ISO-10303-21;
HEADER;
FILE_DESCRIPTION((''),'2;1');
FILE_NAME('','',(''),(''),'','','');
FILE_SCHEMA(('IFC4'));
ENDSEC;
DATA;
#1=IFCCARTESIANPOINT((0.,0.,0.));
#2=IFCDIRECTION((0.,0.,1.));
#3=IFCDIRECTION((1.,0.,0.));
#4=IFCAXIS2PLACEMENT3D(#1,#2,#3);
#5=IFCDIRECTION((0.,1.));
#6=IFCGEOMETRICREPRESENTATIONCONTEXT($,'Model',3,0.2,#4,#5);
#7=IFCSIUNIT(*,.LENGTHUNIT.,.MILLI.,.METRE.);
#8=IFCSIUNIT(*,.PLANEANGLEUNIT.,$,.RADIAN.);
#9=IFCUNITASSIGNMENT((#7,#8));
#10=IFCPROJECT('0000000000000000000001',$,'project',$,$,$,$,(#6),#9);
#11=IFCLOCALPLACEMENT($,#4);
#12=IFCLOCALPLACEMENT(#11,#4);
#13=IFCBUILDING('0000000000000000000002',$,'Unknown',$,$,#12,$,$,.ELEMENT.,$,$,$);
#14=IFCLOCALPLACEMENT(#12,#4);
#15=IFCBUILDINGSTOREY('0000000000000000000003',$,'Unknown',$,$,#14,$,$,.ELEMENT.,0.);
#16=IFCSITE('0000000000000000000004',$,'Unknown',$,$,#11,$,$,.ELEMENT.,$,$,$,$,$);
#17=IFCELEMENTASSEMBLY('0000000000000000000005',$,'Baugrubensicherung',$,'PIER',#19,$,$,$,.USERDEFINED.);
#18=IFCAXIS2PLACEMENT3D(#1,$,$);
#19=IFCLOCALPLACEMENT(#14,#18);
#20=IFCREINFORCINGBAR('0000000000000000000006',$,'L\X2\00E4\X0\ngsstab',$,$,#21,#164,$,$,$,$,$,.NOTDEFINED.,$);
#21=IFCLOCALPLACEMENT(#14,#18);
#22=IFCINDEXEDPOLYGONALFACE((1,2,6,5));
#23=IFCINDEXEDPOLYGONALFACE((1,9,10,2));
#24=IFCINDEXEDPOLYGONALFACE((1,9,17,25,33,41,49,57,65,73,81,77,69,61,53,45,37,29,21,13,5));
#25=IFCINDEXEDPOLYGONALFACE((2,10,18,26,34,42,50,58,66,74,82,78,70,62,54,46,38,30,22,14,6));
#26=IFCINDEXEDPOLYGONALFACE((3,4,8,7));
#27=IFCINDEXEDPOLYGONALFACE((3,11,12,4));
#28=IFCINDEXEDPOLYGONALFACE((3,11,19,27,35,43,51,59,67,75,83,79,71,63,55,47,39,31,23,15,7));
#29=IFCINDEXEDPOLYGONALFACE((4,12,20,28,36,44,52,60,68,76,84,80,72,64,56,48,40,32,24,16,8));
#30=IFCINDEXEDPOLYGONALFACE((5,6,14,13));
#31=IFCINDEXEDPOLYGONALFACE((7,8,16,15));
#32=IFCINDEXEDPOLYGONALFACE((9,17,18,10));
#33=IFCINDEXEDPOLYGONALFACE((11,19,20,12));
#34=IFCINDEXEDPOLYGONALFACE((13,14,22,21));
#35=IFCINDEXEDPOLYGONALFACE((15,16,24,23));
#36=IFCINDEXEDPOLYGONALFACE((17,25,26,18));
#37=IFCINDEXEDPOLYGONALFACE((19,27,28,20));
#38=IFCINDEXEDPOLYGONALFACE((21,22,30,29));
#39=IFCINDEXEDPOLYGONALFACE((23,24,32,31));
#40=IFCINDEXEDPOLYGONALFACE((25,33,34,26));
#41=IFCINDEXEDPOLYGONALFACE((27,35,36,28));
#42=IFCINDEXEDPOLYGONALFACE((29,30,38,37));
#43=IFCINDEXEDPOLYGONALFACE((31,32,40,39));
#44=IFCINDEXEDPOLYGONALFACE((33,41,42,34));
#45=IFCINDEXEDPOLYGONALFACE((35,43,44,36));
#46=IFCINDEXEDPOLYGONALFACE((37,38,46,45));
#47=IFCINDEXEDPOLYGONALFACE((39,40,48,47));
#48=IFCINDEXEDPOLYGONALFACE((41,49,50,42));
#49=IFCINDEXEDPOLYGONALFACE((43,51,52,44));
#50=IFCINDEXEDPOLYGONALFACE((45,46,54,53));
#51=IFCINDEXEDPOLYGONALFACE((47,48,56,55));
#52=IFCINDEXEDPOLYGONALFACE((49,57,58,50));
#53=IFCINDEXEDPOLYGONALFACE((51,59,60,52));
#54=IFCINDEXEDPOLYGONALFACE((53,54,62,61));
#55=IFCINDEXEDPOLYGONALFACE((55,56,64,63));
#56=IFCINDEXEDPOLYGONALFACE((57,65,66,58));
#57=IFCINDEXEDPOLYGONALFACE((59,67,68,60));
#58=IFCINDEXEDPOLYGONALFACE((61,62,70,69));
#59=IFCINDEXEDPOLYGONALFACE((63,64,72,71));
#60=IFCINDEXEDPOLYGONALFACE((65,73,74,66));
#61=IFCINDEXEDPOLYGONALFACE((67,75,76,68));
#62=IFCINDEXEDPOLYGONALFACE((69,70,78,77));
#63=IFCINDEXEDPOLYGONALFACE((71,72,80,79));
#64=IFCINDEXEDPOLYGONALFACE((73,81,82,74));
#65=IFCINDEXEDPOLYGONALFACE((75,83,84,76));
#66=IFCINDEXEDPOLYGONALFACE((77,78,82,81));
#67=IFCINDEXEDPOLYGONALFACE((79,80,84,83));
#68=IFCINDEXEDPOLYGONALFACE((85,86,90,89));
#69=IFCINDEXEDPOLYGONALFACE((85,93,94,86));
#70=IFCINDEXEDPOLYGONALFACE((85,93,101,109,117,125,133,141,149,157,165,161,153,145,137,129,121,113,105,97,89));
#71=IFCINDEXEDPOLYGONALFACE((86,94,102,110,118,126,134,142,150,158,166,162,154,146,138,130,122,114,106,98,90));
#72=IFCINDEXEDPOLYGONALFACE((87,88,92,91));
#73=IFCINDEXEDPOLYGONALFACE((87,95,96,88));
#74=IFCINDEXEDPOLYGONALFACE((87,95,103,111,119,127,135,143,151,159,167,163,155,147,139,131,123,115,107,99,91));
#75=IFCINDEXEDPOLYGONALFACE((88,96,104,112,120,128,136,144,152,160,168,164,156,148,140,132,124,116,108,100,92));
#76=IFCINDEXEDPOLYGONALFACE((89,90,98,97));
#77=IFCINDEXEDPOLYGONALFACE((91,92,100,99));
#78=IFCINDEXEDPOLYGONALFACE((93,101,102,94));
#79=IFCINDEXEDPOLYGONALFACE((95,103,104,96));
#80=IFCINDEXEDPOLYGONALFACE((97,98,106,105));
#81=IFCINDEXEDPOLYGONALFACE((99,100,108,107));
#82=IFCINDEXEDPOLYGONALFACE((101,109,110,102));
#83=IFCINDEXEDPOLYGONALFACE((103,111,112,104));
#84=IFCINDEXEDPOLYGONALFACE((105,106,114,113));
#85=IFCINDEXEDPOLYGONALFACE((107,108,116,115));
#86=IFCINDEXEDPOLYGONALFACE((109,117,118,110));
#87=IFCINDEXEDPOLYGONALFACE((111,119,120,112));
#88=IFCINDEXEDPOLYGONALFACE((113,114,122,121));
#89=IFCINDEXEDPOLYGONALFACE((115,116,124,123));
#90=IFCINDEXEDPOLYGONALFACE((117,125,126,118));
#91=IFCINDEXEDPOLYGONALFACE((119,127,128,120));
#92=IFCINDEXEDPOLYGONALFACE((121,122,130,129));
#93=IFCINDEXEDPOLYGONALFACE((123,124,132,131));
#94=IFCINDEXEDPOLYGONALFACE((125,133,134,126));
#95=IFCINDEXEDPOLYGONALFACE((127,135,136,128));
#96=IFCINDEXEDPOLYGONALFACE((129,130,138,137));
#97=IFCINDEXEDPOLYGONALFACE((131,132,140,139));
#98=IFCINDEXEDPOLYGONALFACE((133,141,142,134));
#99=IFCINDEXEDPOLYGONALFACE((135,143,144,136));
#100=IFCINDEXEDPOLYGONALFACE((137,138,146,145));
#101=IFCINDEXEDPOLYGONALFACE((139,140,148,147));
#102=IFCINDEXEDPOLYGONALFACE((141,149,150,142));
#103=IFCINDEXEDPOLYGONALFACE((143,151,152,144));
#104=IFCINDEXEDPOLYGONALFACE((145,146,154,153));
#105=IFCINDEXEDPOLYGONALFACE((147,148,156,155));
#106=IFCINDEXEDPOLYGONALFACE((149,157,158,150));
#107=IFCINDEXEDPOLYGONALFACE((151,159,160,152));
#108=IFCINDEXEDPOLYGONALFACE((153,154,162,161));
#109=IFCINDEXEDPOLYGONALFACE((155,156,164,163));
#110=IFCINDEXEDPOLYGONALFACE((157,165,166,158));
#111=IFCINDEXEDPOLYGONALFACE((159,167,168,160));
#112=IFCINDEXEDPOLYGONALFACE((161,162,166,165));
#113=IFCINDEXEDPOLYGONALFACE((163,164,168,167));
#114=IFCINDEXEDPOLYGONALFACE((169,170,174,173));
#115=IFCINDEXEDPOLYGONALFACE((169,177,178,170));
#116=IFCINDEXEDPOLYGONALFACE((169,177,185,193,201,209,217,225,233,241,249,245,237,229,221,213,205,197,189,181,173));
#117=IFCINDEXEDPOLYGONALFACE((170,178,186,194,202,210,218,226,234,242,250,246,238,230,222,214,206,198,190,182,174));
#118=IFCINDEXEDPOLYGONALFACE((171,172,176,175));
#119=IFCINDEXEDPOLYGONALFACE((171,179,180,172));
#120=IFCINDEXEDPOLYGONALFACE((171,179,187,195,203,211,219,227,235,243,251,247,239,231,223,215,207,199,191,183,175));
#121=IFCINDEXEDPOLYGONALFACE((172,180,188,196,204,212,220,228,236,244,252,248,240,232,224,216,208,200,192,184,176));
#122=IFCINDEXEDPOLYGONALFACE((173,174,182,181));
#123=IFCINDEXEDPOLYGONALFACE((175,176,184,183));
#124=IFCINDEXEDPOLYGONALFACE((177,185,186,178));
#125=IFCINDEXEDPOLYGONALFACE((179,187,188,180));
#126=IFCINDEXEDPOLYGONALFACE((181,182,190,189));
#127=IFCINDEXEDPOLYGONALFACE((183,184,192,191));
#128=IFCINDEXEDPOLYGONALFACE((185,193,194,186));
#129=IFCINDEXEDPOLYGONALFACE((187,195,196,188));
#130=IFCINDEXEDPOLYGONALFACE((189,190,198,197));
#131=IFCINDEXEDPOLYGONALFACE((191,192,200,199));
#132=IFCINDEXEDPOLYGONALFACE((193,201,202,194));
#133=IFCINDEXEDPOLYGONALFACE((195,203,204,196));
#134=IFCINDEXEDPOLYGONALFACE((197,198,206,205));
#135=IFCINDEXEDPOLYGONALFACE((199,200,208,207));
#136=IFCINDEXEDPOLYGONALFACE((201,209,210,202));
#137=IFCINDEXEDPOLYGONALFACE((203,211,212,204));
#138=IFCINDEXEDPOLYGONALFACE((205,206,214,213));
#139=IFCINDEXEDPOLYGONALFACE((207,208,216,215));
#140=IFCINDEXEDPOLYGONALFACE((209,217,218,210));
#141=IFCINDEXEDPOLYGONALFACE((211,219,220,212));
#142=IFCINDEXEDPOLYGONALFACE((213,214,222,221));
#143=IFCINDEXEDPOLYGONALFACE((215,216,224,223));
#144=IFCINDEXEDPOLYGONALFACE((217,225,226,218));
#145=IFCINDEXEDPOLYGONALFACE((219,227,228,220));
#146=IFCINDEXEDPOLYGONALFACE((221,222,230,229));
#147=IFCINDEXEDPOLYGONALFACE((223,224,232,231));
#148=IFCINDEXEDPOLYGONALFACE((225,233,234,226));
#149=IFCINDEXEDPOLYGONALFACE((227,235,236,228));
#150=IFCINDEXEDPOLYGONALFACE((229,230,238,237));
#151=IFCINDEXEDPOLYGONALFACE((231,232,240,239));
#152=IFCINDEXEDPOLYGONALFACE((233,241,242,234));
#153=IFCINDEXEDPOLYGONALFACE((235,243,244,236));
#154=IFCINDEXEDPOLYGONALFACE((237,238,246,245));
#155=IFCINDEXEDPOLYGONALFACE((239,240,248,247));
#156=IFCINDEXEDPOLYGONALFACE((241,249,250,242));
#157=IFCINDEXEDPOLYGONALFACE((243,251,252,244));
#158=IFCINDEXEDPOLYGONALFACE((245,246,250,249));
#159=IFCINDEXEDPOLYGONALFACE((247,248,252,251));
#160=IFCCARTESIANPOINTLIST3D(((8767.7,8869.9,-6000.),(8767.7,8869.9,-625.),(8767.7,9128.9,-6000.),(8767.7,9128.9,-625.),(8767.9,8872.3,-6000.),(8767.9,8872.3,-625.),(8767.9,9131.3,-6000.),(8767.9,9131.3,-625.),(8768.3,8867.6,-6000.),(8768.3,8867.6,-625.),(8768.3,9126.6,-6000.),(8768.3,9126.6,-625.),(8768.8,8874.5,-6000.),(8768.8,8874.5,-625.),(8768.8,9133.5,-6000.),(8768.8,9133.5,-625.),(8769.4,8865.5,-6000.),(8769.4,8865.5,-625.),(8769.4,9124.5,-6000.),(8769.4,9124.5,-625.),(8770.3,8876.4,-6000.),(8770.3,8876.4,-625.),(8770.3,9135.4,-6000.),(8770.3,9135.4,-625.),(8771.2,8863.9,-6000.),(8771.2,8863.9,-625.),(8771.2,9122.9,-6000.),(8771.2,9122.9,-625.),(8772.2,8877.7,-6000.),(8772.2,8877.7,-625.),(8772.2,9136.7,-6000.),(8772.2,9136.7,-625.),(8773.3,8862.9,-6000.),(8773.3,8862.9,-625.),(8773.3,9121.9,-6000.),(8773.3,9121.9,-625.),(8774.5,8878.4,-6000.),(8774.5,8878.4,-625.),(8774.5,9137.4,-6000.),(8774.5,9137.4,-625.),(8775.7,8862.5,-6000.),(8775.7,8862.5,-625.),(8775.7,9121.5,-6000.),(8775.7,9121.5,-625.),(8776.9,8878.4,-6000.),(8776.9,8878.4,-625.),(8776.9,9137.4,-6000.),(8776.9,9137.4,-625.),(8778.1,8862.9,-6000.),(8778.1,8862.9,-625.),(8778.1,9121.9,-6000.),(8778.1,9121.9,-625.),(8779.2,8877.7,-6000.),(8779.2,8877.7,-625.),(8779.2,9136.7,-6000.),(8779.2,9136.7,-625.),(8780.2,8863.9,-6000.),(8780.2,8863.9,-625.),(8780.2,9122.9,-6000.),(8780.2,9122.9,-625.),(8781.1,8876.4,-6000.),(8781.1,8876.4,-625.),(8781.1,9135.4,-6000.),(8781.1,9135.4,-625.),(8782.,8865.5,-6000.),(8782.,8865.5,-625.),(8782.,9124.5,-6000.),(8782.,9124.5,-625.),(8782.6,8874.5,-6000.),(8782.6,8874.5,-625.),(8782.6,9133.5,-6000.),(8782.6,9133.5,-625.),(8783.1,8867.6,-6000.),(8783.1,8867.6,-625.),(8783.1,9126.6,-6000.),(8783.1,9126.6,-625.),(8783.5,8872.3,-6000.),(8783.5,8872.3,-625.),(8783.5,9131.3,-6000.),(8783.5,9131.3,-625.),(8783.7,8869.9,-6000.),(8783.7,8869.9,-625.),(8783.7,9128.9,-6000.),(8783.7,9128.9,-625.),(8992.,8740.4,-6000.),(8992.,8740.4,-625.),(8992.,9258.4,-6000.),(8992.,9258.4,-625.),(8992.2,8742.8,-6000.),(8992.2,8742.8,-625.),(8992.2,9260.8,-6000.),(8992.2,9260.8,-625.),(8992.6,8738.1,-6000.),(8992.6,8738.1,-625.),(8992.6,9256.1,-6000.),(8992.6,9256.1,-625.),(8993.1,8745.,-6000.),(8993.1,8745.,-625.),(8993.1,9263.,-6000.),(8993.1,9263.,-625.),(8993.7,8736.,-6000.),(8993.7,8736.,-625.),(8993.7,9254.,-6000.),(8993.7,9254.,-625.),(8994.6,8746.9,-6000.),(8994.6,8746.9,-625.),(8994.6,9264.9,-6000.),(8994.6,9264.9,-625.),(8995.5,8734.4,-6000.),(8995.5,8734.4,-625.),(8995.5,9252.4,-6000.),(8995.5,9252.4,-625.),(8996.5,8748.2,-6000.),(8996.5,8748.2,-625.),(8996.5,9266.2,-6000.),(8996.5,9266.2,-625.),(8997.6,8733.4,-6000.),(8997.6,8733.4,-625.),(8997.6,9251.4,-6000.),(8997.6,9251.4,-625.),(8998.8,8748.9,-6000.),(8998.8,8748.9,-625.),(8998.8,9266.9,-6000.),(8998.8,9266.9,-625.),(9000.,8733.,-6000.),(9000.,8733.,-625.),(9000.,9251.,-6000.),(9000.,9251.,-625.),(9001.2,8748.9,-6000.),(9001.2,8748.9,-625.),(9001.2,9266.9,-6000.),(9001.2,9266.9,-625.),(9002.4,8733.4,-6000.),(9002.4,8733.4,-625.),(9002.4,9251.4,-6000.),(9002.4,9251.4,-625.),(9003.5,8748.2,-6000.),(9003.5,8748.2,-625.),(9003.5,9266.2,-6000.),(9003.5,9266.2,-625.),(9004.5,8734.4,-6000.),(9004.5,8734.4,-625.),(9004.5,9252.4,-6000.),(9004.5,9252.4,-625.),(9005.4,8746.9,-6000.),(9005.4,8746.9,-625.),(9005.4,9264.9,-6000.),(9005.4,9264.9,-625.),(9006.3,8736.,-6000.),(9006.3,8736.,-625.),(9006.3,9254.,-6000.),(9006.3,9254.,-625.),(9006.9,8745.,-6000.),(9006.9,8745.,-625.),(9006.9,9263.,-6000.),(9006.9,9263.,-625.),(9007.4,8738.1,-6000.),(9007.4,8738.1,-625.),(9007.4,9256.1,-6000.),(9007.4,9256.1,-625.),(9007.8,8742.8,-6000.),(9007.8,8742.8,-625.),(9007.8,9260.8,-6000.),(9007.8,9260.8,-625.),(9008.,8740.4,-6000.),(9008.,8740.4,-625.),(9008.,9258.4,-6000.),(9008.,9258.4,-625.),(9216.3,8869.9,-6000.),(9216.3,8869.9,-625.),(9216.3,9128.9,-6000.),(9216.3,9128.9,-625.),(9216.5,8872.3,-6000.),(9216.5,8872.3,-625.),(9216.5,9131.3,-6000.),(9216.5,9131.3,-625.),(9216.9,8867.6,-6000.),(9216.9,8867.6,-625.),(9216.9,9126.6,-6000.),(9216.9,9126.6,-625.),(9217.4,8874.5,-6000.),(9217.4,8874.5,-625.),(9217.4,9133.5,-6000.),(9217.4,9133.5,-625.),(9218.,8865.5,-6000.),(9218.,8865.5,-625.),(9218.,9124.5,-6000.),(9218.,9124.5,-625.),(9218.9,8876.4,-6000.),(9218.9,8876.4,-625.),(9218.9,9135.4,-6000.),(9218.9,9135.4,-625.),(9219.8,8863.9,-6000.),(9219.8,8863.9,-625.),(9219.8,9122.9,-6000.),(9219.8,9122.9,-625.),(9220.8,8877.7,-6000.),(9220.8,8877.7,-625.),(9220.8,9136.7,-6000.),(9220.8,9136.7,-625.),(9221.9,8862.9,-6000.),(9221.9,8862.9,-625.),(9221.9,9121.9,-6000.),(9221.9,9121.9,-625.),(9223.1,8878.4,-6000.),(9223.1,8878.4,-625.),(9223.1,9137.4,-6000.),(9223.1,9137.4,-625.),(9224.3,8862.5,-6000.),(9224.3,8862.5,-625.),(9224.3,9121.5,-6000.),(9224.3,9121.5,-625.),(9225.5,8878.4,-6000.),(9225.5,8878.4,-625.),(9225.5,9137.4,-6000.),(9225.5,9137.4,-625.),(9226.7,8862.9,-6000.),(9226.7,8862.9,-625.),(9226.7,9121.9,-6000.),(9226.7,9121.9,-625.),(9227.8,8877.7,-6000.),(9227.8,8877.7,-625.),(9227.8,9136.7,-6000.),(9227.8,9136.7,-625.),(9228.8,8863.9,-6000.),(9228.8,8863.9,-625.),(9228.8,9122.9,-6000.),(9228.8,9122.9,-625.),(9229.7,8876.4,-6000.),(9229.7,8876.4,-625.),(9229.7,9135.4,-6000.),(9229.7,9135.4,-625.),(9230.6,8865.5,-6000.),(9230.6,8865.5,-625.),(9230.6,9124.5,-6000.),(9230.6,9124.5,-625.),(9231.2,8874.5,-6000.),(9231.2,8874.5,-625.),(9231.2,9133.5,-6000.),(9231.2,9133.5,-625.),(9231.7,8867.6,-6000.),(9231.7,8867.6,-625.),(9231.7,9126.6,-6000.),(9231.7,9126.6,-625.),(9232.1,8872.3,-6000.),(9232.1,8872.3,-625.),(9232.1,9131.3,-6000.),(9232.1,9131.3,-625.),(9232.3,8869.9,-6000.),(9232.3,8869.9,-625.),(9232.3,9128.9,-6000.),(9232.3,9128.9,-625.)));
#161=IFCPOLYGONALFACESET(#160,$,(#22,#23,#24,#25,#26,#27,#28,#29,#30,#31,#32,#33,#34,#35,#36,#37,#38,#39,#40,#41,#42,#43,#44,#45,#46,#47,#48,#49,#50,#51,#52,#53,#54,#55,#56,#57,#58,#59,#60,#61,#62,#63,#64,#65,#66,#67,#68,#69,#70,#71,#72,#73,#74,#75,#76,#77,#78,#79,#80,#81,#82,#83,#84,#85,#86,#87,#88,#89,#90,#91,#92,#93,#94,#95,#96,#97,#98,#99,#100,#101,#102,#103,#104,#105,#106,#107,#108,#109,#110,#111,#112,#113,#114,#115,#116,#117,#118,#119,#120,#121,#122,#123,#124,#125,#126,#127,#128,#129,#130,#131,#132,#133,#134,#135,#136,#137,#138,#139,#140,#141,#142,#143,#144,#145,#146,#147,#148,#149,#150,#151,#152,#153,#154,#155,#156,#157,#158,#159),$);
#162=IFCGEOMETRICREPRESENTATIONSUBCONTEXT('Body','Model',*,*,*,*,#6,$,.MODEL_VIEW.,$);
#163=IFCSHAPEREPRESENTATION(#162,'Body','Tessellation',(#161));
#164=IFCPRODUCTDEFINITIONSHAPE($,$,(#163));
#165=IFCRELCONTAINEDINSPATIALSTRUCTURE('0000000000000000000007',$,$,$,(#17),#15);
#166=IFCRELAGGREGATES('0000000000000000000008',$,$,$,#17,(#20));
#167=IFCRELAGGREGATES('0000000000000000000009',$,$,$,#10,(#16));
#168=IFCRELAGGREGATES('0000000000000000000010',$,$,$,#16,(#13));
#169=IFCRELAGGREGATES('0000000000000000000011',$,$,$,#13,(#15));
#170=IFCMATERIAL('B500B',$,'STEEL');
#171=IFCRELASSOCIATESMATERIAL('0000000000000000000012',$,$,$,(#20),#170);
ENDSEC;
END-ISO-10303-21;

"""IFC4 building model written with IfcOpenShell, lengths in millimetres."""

from ifc_helpers import new_model, entity, si_unit, direction, frame, origin_with_axes, place, context, subcontext, project, spatial, source, transform, mapped, material, element, aggregate, save


model = new_model("IFC4")

# Units and contexts
model_context = context("Model", 3, precision=0.2, world=origin_with_axes(), true_north=direction((0.0, 1.0)))
body_context = subcontext(model_context, "Body", "Model", "MODEL_VIEW")
ifc_project = project(units=[si_unit("LENGTHUNIT", "METRE", prefix="MILLI"), si_unit("PLANEANGLEUNIT", "RADIAN")], contexts=[model_context])

# Site, building, storey
site_placement = place(None, origin_with_axes())
site = spatial("IfcSite", under=ifc_project, at=site_placement, Name="Unknown", CompositionType="ELEMENT")
building_placement = place(site_placement, origin_with_axes())
building = spatial("IfcBuilding", under=site, at=building_placement, Name="Unknown", CompositionType="ELEMENT")
storey_placement = place(building_placement, origin_with_axes())
storey = spatial("IfcBuildingStorey", under=building, at=storey_placement, Name="Unknown", CompositionType="ELEMENT", Elevation=0.0)

# Shared definitions
ifc_material_1 = material(Name="B500B", Category="STEEL")

# Element assembly, reinforcing bar
assembly_1_placement = place(storey_placement, frame((9000.0, 9000.0, -6000.0), z_axis=(-1.0, 0.0, 0.0), x_axis=(0.0, 0.0, 1.0)))
assembly_1 = element("IfcElementAssembly", 1, at=assembly_1_placement, inside=storey, Name="Baugrubensicherung", ObjectType="PIER", PredefinedType="USERDEFINED")
shared_shape_1 = source(origin_with_axes(), body_context, "Body", "AdvancedSweptSolid", [
    entity("IfcSweptDiskSolid", entity("IfcIndexedPolyCurve", entity("IfcCartesianPointList3D", [[0.0, 0.0, 0.0], [5375.0, 0.0, 0.0]]), [entity("IfcLineIndex", [1, 2])]), 8.0),
])
reinforcing_bar_1_placement = place(assembly_1_placement, frame((0.0, 259.0, 0.0), z_axis=(0.0, 0.5, 0.866025), x_axis=(1.0, 0.0, 0.0)))
reinforcing_bar_1 = element("IfcReinforcingBar", 2, at=reinforcing_bar_1_placement, material=ifc_material_1, Name="Längsstab", PredefinedType="NOTDEFINED", context=body_context, shape_type="MappedRepresentation", body=[
    mapped(shared_shape_1, transform((0.0, 0.0, 0.0))),
    mapped(shared_shape_1, transform((0.0, -224.3, 129.5))),
    mapped(shared_shape_1, transform((0.0, -448.6, 0.0))),
    mapped(shared_shape_1, transform((0.0, -448.6, -259.0))),
    mapped(shared_shape_1, transform((0.0, -224.3, -388.5))),
    mapped(shared_shape_1, transform((0.0, 0.0, -259.0))),
])

aggregate(assembly_1, [reinforcing_bar_1])

save(model, "model.ifc")
